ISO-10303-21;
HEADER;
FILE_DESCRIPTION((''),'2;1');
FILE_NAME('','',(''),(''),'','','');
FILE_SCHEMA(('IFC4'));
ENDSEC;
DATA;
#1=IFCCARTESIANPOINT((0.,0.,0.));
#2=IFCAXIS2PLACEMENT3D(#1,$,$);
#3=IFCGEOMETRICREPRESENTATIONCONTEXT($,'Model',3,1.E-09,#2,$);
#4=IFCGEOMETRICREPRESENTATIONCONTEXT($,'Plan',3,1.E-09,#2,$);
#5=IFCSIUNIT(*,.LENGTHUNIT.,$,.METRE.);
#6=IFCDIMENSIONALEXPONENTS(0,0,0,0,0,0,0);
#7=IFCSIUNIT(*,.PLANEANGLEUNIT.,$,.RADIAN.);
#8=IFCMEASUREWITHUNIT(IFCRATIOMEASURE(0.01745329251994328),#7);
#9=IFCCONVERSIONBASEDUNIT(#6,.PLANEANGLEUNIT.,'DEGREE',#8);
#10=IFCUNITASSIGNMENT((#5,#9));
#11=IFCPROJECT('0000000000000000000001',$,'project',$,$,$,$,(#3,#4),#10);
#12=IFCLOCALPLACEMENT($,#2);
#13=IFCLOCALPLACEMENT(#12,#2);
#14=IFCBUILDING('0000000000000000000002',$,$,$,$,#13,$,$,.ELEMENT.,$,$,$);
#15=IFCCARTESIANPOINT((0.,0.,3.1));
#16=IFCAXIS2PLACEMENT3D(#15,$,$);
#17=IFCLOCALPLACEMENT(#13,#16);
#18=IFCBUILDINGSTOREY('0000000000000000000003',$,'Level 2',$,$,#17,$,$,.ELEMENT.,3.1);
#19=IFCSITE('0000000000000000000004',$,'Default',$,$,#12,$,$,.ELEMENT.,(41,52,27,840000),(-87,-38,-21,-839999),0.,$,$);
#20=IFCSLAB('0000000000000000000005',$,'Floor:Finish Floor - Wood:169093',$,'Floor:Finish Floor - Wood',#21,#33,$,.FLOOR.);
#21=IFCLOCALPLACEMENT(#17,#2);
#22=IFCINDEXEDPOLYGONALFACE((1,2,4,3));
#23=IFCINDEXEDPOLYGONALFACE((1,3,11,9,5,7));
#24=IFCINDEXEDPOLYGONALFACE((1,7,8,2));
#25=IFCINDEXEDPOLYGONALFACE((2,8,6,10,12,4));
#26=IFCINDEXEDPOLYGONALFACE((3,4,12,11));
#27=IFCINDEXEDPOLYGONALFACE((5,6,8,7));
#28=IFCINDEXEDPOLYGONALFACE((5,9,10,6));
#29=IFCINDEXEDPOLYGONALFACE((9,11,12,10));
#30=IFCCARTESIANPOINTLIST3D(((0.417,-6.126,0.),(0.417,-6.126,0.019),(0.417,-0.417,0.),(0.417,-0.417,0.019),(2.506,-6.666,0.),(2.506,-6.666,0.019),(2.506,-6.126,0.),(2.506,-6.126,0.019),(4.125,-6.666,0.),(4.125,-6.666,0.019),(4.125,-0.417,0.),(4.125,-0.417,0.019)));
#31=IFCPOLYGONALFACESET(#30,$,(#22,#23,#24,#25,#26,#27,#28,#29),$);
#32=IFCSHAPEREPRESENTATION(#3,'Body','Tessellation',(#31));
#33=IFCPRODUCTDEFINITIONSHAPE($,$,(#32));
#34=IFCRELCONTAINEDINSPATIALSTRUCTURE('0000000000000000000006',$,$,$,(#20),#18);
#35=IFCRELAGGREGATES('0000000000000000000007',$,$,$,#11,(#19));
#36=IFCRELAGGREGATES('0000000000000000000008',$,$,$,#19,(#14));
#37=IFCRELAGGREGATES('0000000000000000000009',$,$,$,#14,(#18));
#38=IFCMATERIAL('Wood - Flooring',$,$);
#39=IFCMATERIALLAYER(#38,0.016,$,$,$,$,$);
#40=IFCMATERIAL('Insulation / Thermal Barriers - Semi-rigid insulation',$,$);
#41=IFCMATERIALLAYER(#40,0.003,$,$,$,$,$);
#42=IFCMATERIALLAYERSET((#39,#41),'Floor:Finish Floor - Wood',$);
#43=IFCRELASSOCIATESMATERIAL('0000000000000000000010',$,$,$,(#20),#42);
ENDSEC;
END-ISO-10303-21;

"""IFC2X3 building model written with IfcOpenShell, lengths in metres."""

from ifc_helpers import new_model, entity, si_unit, converted_unit, frame, origin, place, context, project, spatial, polyline, outline, extrude, material, layer, layer_set, layer_usage, element, save


model = new_model("IFC2X3")

# Units and contexts
model_context = context("Model", 3, precision=1e-09, world=origin())
plan_context = context("Plan", 3, precision=1e-09, world=origin())
ifc_project = project(units=[si_unit("LENGTHUNIT", "METRE"), converted_unit("PLANEANGLEUNIT", "DEGREE", entity("IfcRatioMeasure", 0.01745329251994328), si_unit("PLANEANGLEUNIT", "RADIAN"), dimensions=[0, 0, 0, 0, 0, 0, 0])], contexts=[model_context, plan_context])

# Site, building, storey
site_placement = place(None, origin())
site = spatial("IfcSite", under=ifc_project, at=site_placement, Name="Default", CompositionType="ELEMENT", RefLatitude=(41, 52, 27, 840000), RefLongitude=(-87, -38, -21, -839999), RefElevation=0.0)
building_placement = place(site_placement, origin())
building = spatial("IfcBuilding", under=site, at=building_placement, CompositionType="ELEMENT")
storey_placement = place(building_placement, frame((0.0, 0.0, 3.1)))
storey = spatial("IfcBuildingStorey", under=building, at=storey_placement, Name="Level 2", CompositionType="ELEMENT", Elevation=3.1)

# Slab
ifc_material_1 = material(Name="Wood - Flooring")
ifc_layer_1 = layer(ifc_material_1, 0.016)
ifc_material_2 = material(Name="Insulation / Thermal Barriers - Semi-rigid insulation")
ifc_layer_2 = layer(ifc_material_2, 0.003)
ifc_layer_set = layer_set([ifc_layer_1, ifc_layer_2], Name="Floor:Finish Floor - Wood")
ifc_layer_usage = layer_usage(ifc_layer_set, "AXIS3", "POSITIVE", 0.0)
slab_placement = place(storey_placement, frame((0.417, -6.666, 0.0)))
element("IfcSlab", 1, at=slab_placement, inside=storey, material=ifc_layer_usage, Name="Floor:Finish Floor - Wood:169093", ObjectType="Floor:Finish Floor - Wood", PredefinedType="FLOOR", context=model_context, shape_type="SweptSolid", body=[
    extrude(outline(polyline([(1.854, 3.1245), (-1.854, 3.1245), (-1.854, -3.1245), (-0.235, -3.1245), (-0.235, -2.5845), (1.854, -2.5845), (1.854, 3.1245)])), frame((1.854, 3.1245, 0.019), z_axis=(0.0, 0.0, -1.0), x_axis=(-1.0, 0.0, 0.0)), (0.0, 0.0, 1.0), 0.019),
])

save(model, "model.ifc")
